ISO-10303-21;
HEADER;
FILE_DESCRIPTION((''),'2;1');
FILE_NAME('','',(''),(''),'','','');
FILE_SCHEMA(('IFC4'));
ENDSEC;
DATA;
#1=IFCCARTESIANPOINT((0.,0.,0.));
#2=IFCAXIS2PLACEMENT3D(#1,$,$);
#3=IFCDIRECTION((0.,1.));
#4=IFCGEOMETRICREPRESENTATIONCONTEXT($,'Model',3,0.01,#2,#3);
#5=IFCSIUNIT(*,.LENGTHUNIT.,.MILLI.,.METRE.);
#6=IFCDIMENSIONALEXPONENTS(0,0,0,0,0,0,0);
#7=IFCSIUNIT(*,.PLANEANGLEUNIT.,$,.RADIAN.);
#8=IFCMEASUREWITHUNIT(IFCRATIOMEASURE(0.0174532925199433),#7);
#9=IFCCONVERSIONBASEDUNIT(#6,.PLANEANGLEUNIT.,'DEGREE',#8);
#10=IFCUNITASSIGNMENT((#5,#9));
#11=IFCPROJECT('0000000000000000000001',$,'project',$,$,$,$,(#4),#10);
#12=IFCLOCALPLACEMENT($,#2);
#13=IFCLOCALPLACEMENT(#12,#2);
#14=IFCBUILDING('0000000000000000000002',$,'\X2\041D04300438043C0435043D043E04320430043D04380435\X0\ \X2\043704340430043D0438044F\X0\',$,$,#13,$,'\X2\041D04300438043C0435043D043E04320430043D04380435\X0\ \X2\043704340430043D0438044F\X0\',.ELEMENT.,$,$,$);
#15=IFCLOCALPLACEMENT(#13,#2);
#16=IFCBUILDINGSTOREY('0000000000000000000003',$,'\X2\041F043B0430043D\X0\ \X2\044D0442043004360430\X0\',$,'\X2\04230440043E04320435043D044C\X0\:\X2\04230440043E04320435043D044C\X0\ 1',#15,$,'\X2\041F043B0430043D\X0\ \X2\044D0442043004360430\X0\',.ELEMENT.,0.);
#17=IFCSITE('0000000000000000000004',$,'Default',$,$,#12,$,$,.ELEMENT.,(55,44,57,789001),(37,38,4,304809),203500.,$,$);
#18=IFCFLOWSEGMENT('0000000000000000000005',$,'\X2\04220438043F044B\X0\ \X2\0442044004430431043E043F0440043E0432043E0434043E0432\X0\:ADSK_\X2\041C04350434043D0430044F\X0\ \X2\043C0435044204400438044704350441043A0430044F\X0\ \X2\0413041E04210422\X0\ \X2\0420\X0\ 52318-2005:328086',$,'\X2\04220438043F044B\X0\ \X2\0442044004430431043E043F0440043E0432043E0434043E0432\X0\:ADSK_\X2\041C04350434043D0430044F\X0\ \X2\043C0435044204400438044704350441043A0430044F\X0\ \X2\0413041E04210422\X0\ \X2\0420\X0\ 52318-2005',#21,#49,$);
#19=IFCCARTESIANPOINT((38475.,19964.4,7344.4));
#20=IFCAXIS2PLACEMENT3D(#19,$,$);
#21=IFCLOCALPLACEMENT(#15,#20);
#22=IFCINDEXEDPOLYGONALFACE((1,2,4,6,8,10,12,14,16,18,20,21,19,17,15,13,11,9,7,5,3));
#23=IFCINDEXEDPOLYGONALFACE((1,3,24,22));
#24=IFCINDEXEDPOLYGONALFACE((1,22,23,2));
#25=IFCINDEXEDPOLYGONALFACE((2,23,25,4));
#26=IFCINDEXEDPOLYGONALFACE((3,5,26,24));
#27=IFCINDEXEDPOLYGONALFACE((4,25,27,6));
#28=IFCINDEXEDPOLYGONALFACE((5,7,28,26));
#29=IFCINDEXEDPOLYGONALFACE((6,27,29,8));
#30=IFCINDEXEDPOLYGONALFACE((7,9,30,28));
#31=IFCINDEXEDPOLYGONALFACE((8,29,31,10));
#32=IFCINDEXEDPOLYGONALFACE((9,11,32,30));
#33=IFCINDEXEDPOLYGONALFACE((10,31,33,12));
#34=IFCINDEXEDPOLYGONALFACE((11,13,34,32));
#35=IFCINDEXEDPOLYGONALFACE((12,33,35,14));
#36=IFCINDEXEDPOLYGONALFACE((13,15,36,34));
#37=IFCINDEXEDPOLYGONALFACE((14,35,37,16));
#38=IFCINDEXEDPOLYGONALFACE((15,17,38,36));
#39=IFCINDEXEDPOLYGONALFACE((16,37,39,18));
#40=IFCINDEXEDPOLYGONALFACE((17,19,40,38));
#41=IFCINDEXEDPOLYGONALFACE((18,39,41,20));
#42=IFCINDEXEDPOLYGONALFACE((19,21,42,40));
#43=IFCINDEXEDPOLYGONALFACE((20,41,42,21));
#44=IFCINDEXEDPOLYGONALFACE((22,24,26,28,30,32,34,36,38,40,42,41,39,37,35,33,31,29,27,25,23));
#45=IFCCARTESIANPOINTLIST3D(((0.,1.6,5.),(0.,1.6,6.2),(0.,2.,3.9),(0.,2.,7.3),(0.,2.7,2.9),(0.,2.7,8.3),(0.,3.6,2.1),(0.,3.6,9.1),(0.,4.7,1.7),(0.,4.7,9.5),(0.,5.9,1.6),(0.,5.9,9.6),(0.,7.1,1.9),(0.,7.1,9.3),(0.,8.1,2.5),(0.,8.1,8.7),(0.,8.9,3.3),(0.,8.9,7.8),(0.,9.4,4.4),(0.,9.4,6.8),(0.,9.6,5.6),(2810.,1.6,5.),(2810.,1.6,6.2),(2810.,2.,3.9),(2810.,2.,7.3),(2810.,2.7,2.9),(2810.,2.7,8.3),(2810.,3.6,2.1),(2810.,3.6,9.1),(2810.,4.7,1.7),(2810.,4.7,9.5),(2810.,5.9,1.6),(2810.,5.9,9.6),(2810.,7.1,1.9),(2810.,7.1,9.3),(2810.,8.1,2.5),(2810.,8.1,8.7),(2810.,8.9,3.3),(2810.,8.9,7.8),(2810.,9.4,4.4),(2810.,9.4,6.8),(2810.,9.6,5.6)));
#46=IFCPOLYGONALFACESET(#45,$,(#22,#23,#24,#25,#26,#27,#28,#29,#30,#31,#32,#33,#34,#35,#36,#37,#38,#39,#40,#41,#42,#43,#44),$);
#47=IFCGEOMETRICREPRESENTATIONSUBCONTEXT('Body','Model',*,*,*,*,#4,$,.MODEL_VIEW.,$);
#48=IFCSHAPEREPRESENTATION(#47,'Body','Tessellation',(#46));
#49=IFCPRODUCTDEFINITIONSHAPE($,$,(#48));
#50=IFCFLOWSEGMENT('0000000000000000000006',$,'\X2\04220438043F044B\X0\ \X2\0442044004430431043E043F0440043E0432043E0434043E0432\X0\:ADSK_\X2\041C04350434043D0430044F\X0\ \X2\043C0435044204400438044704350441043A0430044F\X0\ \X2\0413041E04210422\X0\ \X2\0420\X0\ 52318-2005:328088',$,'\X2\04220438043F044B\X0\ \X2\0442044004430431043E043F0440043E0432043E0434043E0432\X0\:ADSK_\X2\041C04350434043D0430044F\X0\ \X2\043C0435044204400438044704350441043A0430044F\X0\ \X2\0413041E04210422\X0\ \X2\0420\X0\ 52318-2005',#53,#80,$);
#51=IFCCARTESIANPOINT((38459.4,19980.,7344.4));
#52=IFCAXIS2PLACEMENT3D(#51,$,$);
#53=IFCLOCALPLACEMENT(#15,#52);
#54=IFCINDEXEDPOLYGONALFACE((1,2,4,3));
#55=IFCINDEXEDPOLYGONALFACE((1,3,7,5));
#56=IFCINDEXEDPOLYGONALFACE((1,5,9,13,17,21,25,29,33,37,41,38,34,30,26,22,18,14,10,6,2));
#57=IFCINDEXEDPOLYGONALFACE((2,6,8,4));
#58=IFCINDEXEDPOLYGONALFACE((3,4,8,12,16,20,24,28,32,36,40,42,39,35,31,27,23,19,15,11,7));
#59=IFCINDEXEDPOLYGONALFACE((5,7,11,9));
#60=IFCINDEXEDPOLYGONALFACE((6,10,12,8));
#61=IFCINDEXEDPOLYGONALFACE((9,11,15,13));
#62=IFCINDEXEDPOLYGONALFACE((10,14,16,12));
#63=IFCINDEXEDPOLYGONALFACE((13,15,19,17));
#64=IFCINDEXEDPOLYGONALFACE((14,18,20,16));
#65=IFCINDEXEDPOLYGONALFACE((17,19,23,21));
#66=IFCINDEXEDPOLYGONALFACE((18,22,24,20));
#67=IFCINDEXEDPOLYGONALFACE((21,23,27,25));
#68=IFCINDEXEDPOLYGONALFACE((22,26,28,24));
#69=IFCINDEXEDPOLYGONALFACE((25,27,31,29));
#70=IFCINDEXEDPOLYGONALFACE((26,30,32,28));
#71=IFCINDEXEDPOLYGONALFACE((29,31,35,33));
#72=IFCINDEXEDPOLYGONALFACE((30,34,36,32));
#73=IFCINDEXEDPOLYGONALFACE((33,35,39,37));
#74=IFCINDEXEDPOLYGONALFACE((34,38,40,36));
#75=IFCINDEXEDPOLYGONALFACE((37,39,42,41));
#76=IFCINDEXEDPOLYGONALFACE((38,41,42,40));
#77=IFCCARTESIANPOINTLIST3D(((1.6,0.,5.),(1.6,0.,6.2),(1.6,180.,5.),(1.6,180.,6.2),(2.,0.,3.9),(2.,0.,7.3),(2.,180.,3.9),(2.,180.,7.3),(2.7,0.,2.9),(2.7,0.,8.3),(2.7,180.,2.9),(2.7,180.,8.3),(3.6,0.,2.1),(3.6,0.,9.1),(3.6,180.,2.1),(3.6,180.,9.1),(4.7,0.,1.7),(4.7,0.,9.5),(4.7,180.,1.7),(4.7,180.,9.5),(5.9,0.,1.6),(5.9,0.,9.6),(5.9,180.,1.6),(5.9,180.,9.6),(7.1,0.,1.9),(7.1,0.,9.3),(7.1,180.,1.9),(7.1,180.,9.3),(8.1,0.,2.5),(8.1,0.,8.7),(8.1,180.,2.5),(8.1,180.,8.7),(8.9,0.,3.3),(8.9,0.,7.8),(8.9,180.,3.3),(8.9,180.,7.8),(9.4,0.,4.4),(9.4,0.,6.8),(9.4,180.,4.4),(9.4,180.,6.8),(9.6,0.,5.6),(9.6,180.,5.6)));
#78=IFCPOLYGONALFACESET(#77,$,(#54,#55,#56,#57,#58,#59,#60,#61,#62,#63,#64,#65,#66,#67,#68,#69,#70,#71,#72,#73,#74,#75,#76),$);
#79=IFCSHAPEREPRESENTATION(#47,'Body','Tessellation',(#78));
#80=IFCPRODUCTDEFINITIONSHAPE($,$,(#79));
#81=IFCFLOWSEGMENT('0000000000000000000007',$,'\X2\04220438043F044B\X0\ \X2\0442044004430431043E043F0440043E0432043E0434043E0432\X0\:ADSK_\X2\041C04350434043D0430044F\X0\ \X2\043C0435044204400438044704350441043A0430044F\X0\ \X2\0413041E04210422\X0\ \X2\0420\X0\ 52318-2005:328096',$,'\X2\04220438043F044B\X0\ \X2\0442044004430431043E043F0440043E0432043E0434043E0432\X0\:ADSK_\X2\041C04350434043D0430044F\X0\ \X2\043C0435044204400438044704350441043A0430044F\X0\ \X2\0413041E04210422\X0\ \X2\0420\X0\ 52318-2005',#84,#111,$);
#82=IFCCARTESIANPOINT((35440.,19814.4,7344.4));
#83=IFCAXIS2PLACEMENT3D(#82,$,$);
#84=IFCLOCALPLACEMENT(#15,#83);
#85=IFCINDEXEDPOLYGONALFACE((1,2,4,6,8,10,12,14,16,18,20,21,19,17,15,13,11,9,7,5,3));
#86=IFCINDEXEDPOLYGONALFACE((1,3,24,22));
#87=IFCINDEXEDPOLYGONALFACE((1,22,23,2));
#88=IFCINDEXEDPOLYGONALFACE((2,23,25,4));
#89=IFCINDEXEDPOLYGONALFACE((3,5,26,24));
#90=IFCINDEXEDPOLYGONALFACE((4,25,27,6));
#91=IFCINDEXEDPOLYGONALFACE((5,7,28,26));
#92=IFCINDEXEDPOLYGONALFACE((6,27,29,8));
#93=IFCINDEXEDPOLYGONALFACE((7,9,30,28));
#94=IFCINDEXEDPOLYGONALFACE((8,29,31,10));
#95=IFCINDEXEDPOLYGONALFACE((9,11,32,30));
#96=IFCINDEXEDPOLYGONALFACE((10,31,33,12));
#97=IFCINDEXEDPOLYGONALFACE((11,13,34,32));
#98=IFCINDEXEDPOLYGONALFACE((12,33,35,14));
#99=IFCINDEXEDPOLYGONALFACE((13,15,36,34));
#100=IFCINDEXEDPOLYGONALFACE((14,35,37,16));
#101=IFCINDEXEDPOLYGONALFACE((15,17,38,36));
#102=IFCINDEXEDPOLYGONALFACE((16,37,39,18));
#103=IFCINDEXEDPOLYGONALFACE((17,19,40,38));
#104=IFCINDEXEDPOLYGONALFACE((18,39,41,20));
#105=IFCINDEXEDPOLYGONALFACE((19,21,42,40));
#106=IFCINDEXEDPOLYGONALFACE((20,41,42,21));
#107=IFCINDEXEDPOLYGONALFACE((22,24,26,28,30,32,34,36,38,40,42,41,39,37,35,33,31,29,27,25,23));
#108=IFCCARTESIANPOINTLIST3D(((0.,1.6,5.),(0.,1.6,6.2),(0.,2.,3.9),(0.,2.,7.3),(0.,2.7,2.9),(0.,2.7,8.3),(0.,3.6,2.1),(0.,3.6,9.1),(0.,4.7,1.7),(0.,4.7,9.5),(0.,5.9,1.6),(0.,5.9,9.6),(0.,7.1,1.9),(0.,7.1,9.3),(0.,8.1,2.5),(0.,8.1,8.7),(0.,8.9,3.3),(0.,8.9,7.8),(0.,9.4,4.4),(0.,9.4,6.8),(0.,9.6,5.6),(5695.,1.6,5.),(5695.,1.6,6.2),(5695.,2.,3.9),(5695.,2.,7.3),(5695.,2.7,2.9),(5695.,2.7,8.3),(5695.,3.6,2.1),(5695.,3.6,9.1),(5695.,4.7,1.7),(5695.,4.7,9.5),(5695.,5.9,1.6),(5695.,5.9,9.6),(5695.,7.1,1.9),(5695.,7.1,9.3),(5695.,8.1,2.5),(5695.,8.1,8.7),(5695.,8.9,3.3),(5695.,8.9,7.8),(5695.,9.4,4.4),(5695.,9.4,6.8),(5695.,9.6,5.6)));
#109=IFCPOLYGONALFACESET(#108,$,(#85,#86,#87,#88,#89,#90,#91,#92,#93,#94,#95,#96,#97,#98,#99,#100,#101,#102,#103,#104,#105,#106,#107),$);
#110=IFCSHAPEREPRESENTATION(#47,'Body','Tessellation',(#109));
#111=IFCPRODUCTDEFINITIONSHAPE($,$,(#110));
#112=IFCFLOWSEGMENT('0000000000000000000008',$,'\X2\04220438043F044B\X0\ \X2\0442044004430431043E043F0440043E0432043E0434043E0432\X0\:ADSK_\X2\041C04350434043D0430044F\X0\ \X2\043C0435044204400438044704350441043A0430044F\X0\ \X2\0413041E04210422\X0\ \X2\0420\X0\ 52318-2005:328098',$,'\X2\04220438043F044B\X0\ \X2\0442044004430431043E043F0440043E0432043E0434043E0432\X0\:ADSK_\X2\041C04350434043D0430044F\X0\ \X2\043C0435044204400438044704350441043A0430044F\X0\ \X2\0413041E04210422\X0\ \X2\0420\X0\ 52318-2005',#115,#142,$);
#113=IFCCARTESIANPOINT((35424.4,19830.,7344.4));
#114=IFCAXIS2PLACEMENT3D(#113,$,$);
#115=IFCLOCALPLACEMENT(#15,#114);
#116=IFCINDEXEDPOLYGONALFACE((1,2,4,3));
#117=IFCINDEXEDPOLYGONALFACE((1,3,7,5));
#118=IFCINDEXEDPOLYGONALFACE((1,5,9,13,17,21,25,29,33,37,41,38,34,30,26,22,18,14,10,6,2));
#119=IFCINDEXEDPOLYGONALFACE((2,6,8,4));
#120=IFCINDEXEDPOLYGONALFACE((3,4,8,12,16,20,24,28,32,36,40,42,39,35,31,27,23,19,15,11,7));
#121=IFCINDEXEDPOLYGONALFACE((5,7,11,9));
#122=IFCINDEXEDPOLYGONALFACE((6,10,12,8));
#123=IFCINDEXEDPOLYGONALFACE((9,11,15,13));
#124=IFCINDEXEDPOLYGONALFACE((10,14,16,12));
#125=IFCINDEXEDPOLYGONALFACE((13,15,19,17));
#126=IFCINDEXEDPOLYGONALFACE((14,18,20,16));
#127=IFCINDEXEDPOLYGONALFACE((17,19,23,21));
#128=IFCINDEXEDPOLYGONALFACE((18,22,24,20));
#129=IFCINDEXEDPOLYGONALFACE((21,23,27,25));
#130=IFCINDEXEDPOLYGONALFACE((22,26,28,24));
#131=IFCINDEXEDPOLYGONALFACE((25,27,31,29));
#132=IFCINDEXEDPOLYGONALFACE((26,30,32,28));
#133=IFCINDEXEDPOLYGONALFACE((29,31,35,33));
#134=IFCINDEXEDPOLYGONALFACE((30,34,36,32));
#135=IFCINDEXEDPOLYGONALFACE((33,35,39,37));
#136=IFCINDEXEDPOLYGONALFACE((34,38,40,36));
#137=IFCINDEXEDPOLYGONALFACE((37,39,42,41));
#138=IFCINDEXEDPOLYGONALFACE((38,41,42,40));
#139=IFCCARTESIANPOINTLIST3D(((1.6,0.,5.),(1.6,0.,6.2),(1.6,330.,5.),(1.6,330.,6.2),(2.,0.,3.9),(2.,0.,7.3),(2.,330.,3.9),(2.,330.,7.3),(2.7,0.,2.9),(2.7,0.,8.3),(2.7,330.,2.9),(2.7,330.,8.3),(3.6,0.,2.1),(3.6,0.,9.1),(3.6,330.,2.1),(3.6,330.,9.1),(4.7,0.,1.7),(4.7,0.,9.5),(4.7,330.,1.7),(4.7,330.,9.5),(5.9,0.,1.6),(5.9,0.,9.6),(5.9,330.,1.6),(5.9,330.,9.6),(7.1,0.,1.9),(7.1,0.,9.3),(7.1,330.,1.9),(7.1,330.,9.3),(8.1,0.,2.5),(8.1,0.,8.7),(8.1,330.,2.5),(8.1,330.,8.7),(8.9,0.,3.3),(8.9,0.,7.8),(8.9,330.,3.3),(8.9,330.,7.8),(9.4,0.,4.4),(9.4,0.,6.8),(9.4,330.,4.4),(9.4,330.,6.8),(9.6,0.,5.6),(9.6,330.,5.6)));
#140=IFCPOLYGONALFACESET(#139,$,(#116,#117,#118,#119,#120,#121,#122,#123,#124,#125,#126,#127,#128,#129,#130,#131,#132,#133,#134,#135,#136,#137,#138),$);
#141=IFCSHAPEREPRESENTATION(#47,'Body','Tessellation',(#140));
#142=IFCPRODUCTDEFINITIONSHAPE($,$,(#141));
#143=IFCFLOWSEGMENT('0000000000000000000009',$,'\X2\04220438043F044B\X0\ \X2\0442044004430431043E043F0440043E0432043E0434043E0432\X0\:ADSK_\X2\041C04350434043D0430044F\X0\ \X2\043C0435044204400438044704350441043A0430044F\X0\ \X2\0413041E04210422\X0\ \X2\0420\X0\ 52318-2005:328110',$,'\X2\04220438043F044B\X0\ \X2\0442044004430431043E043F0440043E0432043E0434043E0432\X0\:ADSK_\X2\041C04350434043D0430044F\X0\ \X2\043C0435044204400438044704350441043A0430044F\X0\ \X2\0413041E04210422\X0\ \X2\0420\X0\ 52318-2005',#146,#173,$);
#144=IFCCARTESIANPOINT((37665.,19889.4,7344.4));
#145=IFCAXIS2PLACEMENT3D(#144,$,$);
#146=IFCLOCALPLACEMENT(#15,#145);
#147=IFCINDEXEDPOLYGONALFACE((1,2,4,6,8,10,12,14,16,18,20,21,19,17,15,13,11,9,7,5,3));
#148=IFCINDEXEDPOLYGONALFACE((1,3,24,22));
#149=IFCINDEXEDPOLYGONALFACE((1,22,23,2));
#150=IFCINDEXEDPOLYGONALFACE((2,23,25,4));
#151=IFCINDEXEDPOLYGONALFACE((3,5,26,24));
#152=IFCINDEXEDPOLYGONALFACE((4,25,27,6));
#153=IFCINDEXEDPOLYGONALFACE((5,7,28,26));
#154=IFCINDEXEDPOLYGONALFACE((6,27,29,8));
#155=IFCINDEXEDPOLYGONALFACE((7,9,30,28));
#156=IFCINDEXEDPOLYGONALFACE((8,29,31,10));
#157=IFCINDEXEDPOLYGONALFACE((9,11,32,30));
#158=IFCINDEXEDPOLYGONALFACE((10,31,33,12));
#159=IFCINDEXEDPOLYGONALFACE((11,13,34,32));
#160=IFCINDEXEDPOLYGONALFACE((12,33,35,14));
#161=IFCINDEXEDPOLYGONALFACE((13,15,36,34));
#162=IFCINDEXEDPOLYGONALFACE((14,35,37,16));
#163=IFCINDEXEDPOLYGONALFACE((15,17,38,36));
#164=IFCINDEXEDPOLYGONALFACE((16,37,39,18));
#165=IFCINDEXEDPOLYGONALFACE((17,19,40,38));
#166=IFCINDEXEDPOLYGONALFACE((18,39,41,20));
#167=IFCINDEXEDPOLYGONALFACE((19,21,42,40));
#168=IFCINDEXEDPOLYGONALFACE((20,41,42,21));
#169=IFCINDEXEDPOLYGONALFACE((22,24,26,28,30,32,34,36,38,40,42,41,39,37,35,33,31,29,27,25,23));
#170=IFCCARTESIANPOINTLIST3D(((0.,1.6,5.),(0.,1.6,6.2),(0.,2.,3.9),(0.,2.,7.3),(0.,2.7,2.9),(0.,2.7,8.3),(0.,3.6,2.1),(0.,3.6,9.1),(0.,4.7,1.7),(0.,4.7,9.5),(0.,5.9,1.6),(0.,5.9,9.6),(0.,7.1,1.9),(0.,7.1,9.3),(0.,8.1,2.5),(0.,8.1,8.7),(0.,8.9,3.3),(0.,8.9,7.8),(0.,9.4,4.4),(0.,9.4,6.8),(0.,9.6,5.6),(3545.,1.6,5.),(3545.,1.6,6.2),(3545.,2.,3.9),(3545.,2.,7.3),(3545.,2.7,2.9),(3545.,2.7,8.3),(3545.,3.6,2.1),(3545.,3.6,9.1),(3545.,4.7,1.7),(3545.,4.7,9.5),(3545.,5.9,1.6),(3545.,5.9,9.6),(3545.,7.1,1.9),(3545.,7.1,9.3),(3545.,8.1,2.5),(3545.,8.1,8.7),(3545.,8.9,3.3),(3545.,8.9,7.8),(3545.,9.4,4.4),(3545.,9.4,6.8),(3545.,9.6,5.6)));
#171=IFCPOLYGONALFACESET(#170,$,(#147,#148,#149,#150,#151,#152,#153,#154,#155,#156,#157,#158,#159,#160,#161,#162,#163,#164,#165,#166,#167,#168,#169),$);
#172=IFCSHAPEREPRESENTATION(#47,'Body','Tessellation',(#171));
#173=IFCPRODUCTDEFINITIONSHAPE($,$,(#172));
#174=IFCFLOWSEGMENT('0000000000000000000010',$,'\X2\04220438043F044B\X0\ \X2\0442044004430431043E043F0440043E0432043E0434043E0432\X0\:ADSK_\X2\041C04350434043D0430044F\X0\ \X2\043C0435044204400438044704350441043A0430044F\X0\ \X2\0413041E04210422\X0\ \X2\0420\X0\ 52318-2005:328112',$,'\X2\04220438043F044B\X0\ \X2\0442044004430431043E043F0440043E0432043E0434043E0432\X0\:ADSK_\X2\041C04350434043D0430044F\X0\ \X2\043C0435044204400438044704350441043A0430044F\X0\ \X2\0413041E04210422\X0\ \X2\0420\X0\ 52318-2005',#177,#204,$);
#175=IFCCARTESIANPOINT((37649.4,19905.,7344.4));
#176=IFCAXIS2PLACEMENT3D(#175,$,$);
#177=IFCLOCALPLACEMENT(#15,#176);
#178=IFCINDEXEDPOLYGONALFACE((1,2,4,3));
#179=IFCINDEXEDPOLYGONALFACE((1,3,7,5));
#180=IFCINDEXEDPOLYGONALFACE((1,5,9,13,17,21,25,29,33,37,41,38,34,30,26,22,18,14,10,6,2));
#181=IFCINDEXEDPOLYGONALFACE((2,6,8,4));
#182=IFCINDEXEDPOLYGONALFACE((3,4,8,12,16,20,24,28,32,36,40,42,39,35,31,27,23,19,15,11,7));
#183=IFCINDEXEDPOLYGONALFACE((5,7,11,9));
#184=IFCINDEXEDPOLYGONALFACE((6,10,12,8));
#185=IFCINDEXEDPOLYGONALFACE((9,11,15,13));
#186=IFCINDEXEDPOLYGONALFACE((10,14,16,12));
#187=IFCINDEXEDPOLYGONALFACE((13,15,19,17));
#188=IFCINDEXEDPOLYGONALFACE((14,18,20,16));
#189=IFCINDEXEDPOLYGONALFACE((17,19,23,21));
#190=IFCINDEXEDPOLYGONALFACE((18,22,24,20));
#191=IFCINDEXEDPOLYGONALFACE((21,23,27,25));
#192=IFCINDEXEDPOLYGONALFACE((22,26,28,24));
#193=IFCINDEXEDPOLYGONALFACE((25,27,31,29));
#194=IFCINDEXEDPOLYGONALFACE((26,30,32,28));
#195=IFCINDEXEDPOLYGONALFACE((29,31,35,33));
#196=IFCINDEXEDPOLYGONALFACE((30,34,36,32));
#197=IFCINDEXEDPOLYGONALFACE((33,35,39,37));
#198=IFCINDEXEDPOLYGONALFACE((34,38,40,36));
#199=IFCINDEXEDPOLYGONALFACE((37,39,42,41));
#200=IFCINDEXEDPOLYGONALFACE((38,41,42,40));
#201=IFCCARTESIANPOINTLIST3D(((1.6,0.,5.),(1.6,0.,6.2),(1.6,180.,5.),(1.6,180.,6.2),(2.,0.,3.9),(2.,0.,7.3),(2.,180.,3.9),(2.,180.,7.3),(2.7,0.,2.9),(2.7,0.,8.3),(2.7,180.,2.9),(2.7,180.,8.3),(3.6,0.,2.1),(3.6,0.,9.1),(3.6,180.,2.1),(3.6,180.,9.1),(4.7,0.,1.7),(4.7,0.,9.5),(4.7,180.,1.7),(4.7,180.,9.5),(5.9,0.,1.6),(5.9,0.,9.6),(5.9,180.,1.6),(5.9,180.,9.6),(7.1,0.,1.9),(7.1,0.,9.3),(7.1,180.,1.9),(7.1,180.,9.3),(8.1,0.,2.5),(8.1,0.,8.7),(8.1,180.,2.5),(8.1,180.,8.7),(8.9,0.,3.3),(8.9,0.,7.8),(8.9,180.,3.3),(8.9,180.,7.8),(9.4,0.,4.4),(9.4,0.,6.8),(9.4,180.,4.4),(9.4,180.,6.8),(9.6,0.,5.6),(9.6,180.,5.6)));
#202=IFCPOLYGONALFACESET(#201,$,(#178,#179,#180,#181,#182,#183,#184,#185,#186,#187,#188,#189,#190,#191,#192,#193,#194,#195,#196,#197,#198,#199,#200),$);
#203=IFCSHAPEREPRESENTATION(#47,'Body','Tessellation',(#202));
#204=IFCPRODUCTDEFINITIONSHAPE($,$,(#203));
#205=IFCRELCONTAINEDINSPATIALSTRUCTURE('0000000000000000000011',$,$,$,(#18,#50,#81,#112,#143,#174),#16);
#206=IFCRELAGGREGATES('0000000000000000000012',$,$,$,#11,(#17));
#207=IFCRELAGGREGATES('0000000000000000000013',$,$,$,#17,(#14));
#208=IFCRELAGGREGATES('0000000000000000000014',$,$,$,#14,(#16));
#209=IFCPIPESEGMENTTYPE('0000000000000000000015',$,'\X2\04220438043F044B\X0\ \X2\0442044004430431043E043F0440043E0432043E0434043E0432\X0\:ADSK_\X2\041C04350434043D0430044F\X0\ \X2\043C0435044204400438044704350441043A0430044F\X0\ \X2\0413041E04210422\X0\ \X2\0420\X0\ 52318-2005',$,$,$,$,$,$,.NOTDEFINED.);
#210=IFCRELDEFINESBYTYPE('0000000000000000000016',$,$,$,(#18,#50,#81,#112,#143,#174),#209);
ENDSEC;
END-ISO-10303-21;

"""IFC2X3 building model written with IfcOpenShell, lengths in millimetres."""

from ifc_helpers import new_model, entity, si_unit, converted_unit, direction, frame, frame_2d, origin, origin_2d_with_axis, place, context, subcontext, project, spatial, circle, extrude, type_object, element, save


model = new_model("IFC2X3")

# Units and contexts
model_context = context("Model", 3, precision=0.01, world=origin(), true_north=direction((0.0, 1.0)))
body_context = subcontext(model_context, "Body", "Model", "MODEL_VIEW")
ifc_project = project(units=[si_unit("LENGTHUNIT", "METRE", prefix="MILLI"), converted_unit("PLANEANGLEUNIT", "DEGREE", entity("IfcRatioMeasure", 0.0174532925199433), si_unit("PLANEANGLEUNIT", "RADIAN"), dimensions=[0, 0, 0, 0, 0, 0, 0])], contexts=[model_context])

# Site, building, storey
site_placement = place(None, frame((0.0, 0.0, 0.0)))
site = spatial("IfcSite", under=ifc_project, at=site_placement, Name="Default", CompositionType="ELEMENT", RefLatitude=(55, 44, 57, 789001), RefLongitude=(37, 38, 4, 304809), RefElevation=203500.0)
building_placement = place(site_placement, origin())
building = spatial("IfcBuilding", under=site, at=building_placement, Name="Наименование здания", LongName="Наименование здания", CompositionType="ELEMENT")
storey_placement = place(building_placement, origin())
storey = spatial("IfcBuildingStorey", under=building, at=storey_placement, Name="План этажа", ObjectType="Уровень:Уровень 1", LongName="План этажа", CompositionType="ELEMENT", Elevation=0.0)

# Flow segments
pipe_segment_type = type_object("IfcPipeSegmentType", Name="Типы трубопроводов:ADSK_Медная метрическая ГОСТ Р 52318-2005", PredefinedType="NOTDEFINED")
flow_segment_1_placement = place(storey_placement, frame((38475.0, 19964.4, 7344.4)))
element("IfcFlowSegment", 1, at=flow_segment_1_placement, inside=storey, type_object=pipe_segment_type, Name="Типы трубопроводов:ADSK_Медная метрическая ГОСТ Р 52318-2005:328086", ObjectType="Типы трубопроводов:ADSK_Медная метрическая ГОСТ Р 52318-2005", context=body_context, shape_type="SweptSolid", body=[
    extrude(circle(Radius=4.0, at=frame_2d((0.0, 0.0), x_axis=(1.0, 0.0))), frame((0.0, 5.6, 5.6), z_axis=(1.0, 0.0, 0.0), x_axis=(0.0, 1.0, 0.0)), (0.0, 0.0, 1.0), 2810.0),
])
flow_segment_2_placement = place(storey_placement, frame((38459.4, 19980.0, 7344.4)))
element("IfcFlowSegment", 2, at=flow_segment_2_placement, inside=storey, type_object=pipe_segment_type, Name="Типы трубопроводов:ADSK_Медная метрическая ГОСТ Р 52318-2005:328088", ObjectType="Типы трубопроводов:ADSK_Медная метрическая ГОСТ Р 52318-2005", context=body_context, shape_type="SweptSolid", body=[
    extrude(circle(Radius=4.0, at=origin_2d_with_axis()), frame((5.6, 0.0, 5.6), z_axis=(0.0, 1.0, 0.0), x_axis=(1.0, 0.0, 0.0)), (0.0, 0.0, 1.0), 180.0),
])
flow_segment_3_placement = place(storey_placement, frame((35440.0, 19814.4, 7344.4)))
element("IfcFlowSegment", 3, at=flow_segment_3_placement, inside=storey, type_object=pipe_segment_type, Name="Типы трубопроводов:ADSK_Медная метрическая ГОСТ Р 52318-2005:328096", ObjectType="Типы трубопроводов:ADSK_Медная метрическая ГОСТ Р 52318-2005", context=body_context, shape_type="SweptSolid", body=[
    extrude(circle(Radius=4.0, at=frame_2d((0.0, 0.0), x_axis=(1.0, 0.0))), frame((0.0, 5.6, 5.6), z_axis=(1.0, 0.0, 0.0), x_axis=(0.0, 1.0, 0.0)), (0.0, 0.0, 1.0), 5695.0),
])
flow_segment_4_placement = place(storey_placement, frame((35424.4, 19830.0, 7344.4)))
element("IfcFlowSegment", 4, at=flow_segment_4_placement, inside=storey, type_object=pipe_segment_type, Name="Типы трубопроводов:ADSK_Медная метрическая ГОСТ Р 52318-2005:328098", ObjectType="Типы трубопроводов:ADSK_Медная метрическая ГОСТ Р 52318-2005", context=body_context, shape_type="SweptSolid", body=[
    extrude(circle(Radius=4.0, at=origin_2d_with_axis()), frame((5.6, 0.0, 5.6), z_axis=(0.0, 1.0, 0.0), x_axis=(1.0, 0.0, 0.0)), (0.0, 0.0, 1.0), 330.0),
])
flow_segment_5_placement = place(storey_placement, frame((37665.0, 19889.4, 7344.4)))
element("IfcFlowSegment", 5, at=flow_segment_5_placement, inside=storey, type_object=pipe_segment_type, Name="Типы трубопроводов:ADSK_Медная метрическая ГОСТ Р 52318-2005:328110", ObjectType="Типы трубопроводов:ADSK_Медная метрическая ГОСТ Р 52318-2005", context=body_context, shape_type="SweptSolid", body=[
    extrude(circle(Radius=4.0, at=frame_2d((0.0, 0.0), x_axis=(1.0, 0.0))), frame((0.0, 5.6, 5.6), z_axis=(1.0, 0.0, 0.0), x_axis=(0.0, 1.0, 0.0)), (0.0, 0.0, 1.0), 3545.0),
])
flow_segment_6_placement = place(storey_placement, frame((37649.4, 19905.0, 7344.4)))
element("IfcFlowSegment", 6, at=flow_segment_6_placement, inside=storey, type_object=pipe_segment_type, Name="Типы трубопроводов:ADSK_Медная метрическая ГОСТ Р 52318-2005:328112", ObjectType="Типы трубопроводов:ADSK_Медная метрическая ГОСТ Р 52318-2005", context=body_context, shape_type="SweptSolid", body=[
    extrude(circle(Radius=4.0, at=origin_2d_with_axis()), frame((5.6, 0.0, 5.6), z_axis=(0.0, 1.0, 0.0), x_axis=(1.0, 0.0, 0.0)), (0.0, 0.0, 1.0), 180.0),
])

save(model, "model.ifc")
